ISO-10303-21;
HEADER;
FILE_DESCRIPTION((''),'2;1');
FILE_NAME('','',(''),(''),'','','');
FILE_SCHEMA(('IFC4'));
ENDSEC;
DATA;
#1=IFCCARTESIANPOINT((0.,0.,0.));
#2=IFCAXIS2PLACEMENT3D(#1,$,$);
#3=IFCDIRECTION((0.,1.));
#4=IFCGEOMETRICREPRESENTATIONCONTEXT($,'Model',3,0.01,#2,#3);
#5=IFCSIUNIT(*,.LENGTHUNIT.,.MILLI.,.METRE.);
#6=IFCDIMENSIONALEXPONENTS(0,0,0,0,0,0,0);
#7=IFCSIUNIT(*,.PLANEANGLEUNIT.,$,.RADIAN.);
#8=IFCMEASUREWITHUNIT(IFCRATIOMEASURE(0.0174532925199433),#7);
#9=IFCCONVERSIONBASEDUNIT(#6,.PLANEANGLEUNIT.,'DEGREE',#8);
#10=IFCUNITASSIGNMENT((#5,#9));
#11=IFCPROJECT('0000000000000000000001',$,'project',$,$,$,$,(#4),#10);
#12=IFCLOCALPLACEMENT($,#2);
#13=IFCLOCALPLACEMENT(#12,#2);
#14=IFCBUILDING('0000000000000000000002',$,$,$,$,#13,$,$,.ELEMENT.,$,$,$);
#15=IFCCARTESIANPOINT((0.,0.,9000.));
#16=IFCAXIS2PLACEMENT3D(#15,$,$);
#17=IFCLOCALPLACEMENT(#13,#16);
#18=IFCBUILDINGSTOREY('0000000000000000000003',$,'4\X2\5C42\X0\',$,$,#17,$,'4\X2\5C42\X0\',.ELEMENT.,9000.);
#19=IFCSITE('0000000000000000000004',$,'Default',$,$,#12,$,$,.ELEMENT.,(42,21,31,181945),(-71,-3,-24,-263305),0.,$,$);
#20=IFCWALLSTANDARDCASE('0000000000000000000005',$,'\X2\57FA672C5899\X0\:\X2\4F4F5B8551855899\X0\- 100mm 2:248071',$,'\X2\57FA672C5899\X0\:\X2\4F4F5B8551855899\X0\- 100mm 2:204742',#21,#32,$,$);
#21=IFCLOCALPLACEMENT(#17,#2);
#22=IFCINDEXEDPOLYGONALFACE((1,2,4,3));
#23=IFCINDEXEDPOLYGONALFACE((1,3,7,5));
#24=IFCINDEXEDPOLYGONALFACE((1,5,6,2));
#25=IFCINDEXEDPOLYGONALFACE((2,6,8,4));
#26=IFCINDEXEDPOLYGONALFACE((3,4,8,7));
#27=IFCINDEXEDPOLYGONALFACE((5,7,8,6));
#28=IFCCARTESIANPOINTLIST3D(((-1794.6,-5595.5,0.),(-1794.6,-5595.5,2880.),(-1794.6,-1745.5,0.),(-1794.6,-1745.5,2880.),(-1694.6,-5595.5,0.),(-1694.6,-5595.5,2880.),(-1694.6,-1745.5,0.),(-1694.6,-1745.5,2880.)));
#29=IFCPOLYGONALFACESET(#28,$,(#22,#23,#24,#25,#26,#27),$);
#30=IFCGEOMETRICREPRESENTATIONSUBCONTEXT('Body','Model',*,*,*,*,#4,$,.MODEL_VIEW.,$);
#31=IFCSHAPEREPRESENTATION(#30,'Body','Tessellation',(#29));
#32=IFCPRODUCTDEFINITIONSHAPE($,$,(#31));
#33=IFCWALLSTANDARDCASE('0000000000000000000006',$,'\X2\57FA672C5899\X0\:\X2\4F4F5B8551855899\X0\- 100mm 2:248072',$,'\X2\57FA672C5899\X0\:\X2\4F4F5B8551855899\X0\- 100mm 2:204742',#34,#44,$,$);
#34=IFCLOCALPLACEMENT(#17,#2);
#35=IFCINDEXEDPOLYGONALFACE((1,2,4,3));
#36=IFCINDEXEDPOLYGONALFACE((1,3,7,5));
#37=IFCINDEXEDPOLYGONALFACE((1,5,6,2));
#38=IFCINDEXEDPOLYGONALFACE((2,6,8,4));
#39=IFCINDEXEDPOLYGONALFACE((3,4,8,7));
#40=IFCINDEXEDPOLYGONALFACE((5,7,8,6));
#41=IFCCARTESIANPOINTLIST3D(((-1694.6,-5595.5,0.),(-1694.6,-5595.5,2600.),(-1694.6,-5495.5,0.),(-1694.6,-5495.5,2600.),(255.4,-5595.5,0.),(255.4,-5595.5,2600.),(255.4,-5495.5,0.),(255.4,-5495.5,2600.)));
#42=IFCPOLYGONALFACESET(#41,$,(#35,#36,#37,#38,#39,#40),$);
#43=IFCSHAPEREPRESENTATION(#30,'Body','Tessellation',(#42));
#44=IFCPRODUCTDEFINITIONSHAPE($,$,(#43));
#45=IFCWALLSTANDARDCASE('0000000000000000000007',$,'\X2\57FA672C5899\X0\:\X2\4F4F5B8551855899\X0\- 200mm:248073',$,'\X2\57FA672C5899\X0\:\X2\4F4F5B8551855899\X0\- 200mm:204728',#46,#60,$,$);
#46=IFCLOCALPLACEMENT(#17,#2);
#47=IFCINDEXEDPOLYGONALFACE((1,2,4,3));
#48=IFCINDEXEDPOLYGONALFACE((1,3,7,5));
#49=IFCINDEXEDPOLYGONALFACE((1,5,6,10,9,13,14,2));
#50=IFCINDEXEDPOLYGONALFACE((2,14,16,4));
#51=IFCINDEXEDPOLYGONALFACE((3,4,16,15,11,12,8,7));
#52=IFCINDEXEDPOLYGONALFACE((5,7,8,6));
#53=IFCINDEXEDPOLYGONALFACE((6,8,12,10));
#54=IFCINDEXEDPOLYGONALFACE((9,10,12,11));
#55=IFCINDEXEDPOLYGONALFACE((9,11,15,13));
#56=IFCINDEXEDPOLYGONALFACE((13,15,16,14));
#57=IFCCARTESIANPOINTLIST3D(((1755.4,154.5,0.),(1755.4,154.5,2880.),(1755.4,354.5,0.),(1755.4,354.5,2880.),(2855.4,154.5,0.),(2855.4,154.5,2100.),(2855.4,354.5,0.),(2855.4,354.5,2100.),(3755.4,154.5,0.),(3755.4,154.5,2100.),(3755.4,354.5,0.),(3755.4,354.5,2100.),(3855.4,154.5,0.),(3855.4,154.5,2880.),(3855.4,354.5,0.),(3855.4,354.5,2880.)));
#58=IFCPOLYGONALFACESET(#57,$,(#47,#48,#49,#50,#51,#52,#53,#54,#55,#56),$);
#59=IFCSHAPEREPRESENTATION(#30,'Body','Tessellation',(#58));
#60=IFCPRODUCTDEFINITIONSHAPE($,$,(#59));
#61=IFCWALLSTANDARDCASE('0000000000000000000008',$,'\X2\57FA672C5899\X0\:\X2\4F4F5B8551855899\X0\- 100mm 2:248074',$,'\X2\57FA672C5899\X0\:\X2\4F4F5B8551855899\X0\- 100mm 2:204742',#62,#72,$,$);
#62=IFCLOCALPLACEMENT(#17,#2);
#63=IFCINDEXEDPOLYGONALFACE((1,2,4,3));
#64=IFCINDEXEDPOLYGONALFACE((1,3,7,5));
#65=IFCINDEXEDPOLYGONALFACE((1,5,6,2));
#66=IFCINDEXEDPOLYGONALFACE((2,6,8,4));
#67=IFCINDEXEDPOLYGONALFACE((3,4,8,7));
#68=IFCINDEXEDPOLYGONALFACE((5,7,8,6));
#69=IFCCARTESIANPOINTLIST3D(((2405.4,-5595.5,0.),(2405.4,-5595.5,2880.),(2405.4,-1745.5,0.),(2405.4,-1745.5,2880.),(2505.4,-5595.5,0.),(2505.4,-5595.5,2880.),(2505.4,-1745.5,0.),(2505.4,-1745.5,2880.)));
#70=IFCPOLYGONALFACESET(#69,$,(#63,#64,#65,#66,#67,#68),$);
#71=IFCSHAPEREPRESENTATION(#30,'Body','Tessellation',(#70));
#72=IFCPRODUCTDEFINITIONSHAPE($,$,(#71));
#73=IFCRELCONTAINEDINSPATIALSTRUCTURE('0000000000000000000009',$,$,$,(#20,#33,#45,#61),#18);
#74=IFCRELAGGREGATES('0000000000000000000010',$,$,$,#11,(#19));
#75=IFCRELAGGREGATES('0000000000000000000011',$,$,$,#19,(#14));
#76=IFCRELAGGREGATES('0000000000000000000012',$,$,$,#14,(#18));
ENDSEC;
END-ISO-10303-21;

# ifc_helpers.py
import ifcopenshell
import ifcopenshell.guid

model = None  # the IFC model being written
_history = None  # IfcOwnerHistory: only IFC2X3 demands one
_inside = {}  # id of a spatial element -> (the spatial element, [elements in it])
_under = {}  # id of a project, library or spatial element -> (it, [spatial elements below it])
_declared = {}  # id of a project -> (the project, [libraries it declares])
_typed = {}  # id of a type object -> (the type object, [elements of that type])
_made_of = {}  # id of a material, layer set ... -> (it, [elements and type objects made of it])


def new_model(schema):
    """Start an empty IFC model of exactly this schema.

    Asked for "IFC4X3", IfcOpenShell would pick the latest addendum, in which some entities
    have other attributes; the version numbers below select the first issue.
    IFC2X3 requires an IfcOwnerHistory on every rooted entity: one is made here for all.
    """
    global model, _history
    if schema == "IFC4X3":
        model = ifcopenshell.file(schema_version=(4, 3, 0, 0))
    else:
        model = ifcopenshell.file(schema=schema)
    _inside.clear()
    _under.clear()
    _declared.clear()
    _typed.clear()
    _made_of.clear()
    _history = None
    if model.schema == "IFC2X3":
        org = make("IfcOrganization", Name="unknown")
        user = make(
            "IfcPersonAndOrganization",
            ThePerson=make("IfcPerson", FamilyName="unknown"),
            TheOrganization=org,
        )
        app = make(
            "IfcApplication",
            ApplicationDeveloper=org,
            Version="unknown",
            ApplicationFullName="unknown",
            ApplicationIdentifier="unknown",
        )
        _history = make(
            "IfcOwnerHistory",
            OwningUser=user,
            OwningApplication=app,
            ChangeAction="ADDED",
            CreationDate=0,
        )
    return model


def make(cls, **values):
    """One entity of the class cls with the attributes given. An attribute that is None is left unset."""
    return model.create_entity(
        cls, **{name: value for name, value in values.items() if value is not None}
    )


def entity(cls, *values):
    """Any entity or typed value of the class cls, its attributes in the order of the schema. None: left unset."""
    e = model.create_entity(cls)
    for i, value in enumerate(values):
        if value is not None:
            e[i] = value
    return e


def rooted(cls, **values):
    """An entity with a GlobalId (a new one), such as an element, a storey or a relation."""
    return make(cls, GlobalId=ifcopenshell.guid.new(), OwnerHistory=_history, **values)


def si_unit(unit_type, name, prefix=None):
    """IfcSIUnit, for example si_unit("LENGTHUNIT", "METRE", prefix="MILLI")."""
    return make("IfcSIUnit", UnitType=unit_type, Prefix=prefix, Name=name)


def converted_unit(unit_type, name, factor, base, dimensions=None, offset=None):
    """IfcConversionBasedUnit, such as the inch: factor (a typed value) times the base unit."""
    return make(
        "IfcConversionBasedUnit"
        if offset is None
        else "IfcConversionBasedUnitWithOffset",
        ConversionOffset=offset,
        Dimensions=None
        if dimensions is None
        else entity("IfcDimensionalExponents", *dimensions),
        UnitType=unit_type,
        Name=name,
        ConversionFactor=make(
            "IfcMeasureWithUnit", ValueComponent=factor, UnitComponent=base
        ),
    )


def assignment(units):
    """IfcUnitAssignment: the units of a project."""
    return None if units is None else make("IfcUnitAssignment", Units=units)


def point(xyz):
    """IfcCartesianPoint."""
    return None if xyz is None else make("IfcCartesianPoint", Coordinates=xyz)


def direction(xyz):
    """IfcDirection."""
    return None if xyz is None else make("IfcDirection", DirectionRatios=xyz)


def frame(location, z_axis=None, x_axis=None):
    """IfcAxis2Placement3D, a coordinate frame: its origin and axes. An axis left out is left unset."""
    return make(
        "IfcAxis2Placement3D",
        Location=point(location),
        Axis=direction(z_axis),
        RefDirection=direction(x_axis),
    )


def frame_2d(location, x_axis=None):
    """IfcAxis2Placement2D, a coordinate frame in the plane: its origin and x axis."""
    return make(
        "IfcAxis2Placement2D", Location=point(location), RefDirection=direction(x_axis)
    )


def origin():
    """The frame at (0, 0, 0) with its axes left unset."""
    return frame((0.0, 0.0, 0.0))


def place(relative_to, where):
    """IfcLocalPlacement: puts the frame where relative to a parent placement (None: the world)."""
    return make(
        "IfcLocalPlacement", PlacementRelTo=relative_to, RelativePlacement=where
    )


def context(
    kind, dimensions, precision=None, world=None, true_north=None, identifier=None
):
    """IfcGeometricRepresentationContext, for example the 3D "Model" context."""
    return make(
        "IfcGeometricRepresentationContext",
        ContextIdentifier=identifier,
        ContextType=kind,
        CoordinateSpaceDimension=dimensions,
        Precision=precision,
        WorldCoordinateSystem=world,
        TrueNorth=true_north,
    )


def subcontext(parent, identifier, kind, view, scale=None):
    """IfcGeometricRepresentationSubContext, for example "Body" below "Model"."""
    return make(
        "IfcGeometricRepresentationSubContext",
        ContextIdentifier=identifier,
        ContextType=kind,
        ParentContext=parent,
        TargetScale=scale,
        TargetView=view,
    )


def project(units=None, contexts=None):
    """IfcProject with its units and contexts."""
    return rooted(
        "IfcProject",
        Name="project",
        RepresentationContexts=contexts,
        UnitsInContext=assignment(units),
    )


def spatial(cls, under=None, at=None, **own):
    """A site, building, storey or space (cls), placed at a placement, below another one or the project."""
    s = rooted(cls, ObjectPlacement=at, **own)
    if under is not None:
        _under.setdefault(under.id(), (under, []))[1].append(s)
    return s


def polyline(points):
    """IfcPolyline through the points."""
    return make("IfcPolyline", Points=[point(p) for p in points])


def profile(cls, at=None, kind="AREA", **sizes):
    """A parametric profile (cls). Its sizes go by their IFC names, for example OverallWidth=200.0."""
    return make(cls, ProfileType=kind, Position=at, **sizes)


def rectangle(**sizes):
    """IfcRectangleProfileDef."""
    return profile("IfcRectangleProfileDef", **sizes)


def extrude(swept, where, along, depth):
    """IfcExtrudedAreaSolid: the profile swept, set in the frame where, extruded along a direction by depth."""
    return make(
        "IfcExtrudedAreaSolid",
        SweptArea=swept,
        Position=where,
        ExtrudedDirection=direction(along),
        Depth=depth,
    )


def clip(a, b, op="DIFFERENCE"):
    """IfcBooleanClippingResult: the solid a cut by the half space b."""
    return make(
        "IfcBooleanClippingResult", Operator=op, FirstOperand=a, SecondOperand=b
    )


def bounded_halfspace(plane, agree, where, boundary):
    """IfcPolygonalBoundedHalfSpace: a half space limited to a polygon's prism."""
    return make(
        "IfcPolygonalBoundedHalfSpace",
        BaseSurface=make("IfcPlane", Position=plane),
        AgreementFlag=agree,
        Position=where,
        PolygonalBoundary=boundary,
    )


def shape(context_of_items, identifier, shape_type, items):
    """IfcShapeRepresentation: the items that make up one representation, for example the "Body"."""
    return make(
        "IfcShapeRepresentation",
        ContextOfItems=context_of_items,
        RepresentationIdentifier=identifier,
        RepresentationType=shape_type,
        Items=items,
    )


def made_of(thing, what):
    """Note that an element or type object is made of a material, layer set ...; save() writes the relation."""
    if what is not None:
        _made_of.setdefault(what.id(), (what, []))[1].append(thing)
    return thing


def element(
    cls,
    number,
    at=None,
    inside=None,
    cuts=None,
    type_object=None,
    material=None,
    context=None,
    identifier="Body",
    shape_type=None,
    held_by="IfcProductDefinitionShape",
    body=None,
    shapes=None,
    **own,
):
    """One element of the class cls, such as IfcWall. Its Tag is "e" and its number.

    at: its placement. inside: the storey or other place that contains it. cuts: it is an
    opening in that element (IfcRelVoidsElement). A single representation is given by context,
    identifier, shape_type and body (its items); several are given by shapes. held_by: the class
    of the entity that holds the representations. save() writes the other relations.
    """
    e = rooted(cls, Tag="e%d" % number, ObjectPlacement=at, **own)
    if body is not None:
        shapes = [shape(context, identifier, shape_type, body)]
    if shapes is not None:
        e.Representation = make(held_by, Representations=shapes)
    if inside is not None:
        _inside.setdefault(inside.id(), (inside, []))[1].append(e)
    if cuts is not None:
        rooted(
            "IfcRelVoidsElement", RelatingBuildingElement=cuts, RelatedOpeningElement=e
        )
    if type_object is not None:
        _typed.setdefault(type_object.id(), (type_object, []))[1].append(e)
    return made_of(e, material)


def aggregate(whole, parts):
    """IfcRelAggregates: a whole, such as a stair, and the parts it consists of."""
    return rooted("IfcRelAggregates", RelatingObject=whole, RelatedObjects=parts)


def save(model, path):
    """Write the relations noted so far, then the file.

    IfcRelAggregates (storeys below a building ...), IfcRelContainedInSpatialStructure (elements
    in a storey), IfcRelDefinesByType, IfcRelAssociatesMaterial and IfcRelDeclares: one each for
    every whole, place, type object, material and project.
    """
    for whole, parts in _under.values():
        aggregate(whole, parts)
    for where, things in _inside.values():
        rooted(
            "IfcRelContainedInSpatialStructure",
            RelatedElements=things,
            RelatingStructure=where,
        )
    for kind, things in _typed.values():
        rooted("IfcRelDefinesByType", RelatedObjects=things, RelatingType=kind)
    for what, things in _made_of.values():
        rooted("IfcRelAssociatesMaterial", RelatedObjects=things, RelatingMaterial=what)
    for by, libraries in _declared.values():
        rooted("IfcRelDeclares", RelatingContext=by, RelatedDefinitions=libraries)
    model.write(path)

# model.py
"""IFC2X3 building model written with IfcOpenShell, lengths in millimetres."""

from ifc_helpers import new_model, entity, si_unit, converted_unit, direction, frame, frame_2d, origin, place, context, subcontext, project, spatial, polyline, rectangle, extrude, clip, bounded_halfspace, element, save


model = new_model("IFC2X3")

# Units and contexts
model_context = context("Model", 3, precision=0.01, world=origin(), true_north=direction((0.0, 1.0)))
body_context = subcontext(model_context, "Body", "Model", "MODEL_VIEW")
ifc_project = project(units=[si_unit("LENGTHUNIT", "METRE", prefix="MILLI"), converted_unit("PLANEANGLEUNIT", "DEGREE", entity("IfcRatioMeasure", 0.0174532925199433), si_unit("PLANEANGLEUNIT", "RADIAN"), dimensions=[0, 0, 0, 0, 0, 0, 0])], contexts=[model_context])

# Site, building, storey
site_placement = place(None, origin())
site = spatial("IfcSite", under=ifc_project, at=site_placement, Name="Default", CompositionType="ELEMENT", RefLatitude=(42, 21, 31, 181945), RefLongitude=(-71, -3, -24, -263305), RefElevation=0.0)
building_placement = place(site_placement, origin())
building = spatial("IfcBuilding", under=site, at=building_placement, CompositionType="ELEMENT")
storey_placement = place(building_placement, frame((0.0, 0.0, 9000.0)))
storey = spatial("IfcBuildingStorey", under=building, at=storey_placement, Name="4层", LongName="4层", CompositionType="ELEMENT", Elevation=9000.0)

# Walls
wall_1_placement = place(storey_placement, frame((-1744.6, -1745.5, 0.0), z_axis=(0.0, 0.0, 1.0), x_axis=(0.0, -1.0, 0.0)))
element("IfcWallStandardCase", 1, at=wall_1_placement, inside=storey, Name="基本墙:住宅内墙- 100mm 2:248071", ObjectType="基本墙:住宅内墙- 100mm 2:204742", context=body_context, shape_type="Clipping", body=[
    clip(extrude(rectangle(XDim=3850.0, YDim=100.0, at=frame_2d((1925.0, 0.0), x_axis=(-1.0, 0.0))), origin(), (0.0, 0.0, 1.0), 2880.0), bounded_halfspace(frame((0.0, -50.0, 2880.0), z_axis=(0.0, 0.0, -1.0), x_axis=(1.0, 0.0, 0.0)), True, frame((0.0, -50.0, 2880.0)), polyline([(0.0, 0.0), (3850.0, 0.0), (3850.0, 100.0), (3750.0, 100.0), (200.0, 100.0), (0.0, 100.0), (0.0, 0.0)]))),
])
wall_2_placement = place(storey_placement, frame((-1694.6, -5545.5, 0.0)))
element("IfcWallStandardCase", 2, at=wall_2_placement, inside=storey, Name="基本墙:住宅内墙- 100mm 2:248072", ObjectType="基本墙:住宅内墙- 100mm 2:204742", context=body_context, shape_type="Clipping", body=[
    clip(extrude(rectangle(XDim=1950.0, YDim=100.0, at=frame_2d((975.0, 0.0), x_axis=(-1.0, 0.0))), origin(), (0.0, 0.0, 1.0), 2600.0), bounded_halfspace(frame((0.0, -50.0, 2600.0), z_axis=(0.0, 0.0, -1.0), x_axis=(-1.0, 0.0, 0.0)), True, frame((0.0, -50.0, 2600.0), z_axis=(0.0, 0.0, -1.0), x_axis=(-1.0, 0.0, 0.0)), polyline([(0.0, 0.0), (0.0, 100.0), (-1950.0, 100.0), (-1950.0, 0.0), (0.0, 0.0)]))),
])

# Wall, opening
wall_3_placement = place(storey_placement, frame((3855.4, 254.5, 0.0), z_axis=(0.0, 0.0, 1.0), x_axis=(-1.0, 0.0, 0.0)))
wall_3 = element("IfcWallStandardCase", 3, at=wall_3_placement, inside=storey, Name="基本墙:住宅内墙- 200mm:248073", ObjectType="基本墙:住宅内墙- 200mm:204728", context=body_context, shape_type="Clipping", body=[
    clip(extrude(rectangle(XDim=2100.0, YDim=200.0, at=frame_2d((1050.0, 0.0), x_axis=(-1.0, 0.0))), origin(), (0.0, 0.0, 1.0), 2880.0), bounded_halfspace(frame((0.0, -100.0, 2880.0), z_axis=(0.0, 0.0, -1.0), x_axis=(0.0, 1.0, 0.0)), True, frame((0.0, -100.0, 2880.0)), polyline([(0.0, 0.0), (2100.0, 0.0), (2100.0, 200.0), (0.0, 200.0), (0.0, 0.0)]))),
])
opening_placement = place(wall_3_placement, frame((1000.0, 100.0, 0.0)))
element("IfcOpeningElement", 4, at=opening_placement, cuts=wall_3, ObjectType="Opening", context=body_context, shape_type="SweptSolid", body=[
    extrude(rectangle(XDim=2100.0, YDim=900.0, at=frame_2d((1050.0, 450.0), x_axis=(1.0, 0.0))), frame((0.0, 0.0, 0.0), z_axis=(0.0, -1.0, 0.0), x_axis=(0.0, 0.0, 1.0)), (0.0, 0.0, 1.0), 200.0),
])

# Wall
wall_4_placement = place(storey_placement, frame((2455.4, -1745.5, 0.0), z_axis=(0.0, 0.0, 1.0), x_axis=(0.0, -1.0, 0.0)))
element("IfcWallStandardCase", 5, at=wall_4_placement, inside=storey, Name="基本墙:住宅内墙- 100mm 2:248074", ObjectType="基本墙:住宅内墙- 100mm 2:204742", context=body_context, shape_type="Clipping", body=[
    clip(extrude(rectangle(XDim=3850.0, YDim=100.0, at=frame_2d((1925.0, 0.0), x_axis=(-1.0, 0.0))), origin(), (0.0, 0.0, 1.0), 2880.0), bounded_halfspace(frame((0.0, -50.0, 2880.0), z_axis=(0.0, 0.0, -1.0), x_axis=(1.0, 0.0, 0.0)), True, frame((0.0, -50.0, 2880.0)), polyline([(0.0, 0.0), (200.0, 0.0), (3850.0, 0.0), (3850.0, 100.0), (0.0, 100.0), (0.0, 0.0)]))),
])

save(model, "model.ifc")
